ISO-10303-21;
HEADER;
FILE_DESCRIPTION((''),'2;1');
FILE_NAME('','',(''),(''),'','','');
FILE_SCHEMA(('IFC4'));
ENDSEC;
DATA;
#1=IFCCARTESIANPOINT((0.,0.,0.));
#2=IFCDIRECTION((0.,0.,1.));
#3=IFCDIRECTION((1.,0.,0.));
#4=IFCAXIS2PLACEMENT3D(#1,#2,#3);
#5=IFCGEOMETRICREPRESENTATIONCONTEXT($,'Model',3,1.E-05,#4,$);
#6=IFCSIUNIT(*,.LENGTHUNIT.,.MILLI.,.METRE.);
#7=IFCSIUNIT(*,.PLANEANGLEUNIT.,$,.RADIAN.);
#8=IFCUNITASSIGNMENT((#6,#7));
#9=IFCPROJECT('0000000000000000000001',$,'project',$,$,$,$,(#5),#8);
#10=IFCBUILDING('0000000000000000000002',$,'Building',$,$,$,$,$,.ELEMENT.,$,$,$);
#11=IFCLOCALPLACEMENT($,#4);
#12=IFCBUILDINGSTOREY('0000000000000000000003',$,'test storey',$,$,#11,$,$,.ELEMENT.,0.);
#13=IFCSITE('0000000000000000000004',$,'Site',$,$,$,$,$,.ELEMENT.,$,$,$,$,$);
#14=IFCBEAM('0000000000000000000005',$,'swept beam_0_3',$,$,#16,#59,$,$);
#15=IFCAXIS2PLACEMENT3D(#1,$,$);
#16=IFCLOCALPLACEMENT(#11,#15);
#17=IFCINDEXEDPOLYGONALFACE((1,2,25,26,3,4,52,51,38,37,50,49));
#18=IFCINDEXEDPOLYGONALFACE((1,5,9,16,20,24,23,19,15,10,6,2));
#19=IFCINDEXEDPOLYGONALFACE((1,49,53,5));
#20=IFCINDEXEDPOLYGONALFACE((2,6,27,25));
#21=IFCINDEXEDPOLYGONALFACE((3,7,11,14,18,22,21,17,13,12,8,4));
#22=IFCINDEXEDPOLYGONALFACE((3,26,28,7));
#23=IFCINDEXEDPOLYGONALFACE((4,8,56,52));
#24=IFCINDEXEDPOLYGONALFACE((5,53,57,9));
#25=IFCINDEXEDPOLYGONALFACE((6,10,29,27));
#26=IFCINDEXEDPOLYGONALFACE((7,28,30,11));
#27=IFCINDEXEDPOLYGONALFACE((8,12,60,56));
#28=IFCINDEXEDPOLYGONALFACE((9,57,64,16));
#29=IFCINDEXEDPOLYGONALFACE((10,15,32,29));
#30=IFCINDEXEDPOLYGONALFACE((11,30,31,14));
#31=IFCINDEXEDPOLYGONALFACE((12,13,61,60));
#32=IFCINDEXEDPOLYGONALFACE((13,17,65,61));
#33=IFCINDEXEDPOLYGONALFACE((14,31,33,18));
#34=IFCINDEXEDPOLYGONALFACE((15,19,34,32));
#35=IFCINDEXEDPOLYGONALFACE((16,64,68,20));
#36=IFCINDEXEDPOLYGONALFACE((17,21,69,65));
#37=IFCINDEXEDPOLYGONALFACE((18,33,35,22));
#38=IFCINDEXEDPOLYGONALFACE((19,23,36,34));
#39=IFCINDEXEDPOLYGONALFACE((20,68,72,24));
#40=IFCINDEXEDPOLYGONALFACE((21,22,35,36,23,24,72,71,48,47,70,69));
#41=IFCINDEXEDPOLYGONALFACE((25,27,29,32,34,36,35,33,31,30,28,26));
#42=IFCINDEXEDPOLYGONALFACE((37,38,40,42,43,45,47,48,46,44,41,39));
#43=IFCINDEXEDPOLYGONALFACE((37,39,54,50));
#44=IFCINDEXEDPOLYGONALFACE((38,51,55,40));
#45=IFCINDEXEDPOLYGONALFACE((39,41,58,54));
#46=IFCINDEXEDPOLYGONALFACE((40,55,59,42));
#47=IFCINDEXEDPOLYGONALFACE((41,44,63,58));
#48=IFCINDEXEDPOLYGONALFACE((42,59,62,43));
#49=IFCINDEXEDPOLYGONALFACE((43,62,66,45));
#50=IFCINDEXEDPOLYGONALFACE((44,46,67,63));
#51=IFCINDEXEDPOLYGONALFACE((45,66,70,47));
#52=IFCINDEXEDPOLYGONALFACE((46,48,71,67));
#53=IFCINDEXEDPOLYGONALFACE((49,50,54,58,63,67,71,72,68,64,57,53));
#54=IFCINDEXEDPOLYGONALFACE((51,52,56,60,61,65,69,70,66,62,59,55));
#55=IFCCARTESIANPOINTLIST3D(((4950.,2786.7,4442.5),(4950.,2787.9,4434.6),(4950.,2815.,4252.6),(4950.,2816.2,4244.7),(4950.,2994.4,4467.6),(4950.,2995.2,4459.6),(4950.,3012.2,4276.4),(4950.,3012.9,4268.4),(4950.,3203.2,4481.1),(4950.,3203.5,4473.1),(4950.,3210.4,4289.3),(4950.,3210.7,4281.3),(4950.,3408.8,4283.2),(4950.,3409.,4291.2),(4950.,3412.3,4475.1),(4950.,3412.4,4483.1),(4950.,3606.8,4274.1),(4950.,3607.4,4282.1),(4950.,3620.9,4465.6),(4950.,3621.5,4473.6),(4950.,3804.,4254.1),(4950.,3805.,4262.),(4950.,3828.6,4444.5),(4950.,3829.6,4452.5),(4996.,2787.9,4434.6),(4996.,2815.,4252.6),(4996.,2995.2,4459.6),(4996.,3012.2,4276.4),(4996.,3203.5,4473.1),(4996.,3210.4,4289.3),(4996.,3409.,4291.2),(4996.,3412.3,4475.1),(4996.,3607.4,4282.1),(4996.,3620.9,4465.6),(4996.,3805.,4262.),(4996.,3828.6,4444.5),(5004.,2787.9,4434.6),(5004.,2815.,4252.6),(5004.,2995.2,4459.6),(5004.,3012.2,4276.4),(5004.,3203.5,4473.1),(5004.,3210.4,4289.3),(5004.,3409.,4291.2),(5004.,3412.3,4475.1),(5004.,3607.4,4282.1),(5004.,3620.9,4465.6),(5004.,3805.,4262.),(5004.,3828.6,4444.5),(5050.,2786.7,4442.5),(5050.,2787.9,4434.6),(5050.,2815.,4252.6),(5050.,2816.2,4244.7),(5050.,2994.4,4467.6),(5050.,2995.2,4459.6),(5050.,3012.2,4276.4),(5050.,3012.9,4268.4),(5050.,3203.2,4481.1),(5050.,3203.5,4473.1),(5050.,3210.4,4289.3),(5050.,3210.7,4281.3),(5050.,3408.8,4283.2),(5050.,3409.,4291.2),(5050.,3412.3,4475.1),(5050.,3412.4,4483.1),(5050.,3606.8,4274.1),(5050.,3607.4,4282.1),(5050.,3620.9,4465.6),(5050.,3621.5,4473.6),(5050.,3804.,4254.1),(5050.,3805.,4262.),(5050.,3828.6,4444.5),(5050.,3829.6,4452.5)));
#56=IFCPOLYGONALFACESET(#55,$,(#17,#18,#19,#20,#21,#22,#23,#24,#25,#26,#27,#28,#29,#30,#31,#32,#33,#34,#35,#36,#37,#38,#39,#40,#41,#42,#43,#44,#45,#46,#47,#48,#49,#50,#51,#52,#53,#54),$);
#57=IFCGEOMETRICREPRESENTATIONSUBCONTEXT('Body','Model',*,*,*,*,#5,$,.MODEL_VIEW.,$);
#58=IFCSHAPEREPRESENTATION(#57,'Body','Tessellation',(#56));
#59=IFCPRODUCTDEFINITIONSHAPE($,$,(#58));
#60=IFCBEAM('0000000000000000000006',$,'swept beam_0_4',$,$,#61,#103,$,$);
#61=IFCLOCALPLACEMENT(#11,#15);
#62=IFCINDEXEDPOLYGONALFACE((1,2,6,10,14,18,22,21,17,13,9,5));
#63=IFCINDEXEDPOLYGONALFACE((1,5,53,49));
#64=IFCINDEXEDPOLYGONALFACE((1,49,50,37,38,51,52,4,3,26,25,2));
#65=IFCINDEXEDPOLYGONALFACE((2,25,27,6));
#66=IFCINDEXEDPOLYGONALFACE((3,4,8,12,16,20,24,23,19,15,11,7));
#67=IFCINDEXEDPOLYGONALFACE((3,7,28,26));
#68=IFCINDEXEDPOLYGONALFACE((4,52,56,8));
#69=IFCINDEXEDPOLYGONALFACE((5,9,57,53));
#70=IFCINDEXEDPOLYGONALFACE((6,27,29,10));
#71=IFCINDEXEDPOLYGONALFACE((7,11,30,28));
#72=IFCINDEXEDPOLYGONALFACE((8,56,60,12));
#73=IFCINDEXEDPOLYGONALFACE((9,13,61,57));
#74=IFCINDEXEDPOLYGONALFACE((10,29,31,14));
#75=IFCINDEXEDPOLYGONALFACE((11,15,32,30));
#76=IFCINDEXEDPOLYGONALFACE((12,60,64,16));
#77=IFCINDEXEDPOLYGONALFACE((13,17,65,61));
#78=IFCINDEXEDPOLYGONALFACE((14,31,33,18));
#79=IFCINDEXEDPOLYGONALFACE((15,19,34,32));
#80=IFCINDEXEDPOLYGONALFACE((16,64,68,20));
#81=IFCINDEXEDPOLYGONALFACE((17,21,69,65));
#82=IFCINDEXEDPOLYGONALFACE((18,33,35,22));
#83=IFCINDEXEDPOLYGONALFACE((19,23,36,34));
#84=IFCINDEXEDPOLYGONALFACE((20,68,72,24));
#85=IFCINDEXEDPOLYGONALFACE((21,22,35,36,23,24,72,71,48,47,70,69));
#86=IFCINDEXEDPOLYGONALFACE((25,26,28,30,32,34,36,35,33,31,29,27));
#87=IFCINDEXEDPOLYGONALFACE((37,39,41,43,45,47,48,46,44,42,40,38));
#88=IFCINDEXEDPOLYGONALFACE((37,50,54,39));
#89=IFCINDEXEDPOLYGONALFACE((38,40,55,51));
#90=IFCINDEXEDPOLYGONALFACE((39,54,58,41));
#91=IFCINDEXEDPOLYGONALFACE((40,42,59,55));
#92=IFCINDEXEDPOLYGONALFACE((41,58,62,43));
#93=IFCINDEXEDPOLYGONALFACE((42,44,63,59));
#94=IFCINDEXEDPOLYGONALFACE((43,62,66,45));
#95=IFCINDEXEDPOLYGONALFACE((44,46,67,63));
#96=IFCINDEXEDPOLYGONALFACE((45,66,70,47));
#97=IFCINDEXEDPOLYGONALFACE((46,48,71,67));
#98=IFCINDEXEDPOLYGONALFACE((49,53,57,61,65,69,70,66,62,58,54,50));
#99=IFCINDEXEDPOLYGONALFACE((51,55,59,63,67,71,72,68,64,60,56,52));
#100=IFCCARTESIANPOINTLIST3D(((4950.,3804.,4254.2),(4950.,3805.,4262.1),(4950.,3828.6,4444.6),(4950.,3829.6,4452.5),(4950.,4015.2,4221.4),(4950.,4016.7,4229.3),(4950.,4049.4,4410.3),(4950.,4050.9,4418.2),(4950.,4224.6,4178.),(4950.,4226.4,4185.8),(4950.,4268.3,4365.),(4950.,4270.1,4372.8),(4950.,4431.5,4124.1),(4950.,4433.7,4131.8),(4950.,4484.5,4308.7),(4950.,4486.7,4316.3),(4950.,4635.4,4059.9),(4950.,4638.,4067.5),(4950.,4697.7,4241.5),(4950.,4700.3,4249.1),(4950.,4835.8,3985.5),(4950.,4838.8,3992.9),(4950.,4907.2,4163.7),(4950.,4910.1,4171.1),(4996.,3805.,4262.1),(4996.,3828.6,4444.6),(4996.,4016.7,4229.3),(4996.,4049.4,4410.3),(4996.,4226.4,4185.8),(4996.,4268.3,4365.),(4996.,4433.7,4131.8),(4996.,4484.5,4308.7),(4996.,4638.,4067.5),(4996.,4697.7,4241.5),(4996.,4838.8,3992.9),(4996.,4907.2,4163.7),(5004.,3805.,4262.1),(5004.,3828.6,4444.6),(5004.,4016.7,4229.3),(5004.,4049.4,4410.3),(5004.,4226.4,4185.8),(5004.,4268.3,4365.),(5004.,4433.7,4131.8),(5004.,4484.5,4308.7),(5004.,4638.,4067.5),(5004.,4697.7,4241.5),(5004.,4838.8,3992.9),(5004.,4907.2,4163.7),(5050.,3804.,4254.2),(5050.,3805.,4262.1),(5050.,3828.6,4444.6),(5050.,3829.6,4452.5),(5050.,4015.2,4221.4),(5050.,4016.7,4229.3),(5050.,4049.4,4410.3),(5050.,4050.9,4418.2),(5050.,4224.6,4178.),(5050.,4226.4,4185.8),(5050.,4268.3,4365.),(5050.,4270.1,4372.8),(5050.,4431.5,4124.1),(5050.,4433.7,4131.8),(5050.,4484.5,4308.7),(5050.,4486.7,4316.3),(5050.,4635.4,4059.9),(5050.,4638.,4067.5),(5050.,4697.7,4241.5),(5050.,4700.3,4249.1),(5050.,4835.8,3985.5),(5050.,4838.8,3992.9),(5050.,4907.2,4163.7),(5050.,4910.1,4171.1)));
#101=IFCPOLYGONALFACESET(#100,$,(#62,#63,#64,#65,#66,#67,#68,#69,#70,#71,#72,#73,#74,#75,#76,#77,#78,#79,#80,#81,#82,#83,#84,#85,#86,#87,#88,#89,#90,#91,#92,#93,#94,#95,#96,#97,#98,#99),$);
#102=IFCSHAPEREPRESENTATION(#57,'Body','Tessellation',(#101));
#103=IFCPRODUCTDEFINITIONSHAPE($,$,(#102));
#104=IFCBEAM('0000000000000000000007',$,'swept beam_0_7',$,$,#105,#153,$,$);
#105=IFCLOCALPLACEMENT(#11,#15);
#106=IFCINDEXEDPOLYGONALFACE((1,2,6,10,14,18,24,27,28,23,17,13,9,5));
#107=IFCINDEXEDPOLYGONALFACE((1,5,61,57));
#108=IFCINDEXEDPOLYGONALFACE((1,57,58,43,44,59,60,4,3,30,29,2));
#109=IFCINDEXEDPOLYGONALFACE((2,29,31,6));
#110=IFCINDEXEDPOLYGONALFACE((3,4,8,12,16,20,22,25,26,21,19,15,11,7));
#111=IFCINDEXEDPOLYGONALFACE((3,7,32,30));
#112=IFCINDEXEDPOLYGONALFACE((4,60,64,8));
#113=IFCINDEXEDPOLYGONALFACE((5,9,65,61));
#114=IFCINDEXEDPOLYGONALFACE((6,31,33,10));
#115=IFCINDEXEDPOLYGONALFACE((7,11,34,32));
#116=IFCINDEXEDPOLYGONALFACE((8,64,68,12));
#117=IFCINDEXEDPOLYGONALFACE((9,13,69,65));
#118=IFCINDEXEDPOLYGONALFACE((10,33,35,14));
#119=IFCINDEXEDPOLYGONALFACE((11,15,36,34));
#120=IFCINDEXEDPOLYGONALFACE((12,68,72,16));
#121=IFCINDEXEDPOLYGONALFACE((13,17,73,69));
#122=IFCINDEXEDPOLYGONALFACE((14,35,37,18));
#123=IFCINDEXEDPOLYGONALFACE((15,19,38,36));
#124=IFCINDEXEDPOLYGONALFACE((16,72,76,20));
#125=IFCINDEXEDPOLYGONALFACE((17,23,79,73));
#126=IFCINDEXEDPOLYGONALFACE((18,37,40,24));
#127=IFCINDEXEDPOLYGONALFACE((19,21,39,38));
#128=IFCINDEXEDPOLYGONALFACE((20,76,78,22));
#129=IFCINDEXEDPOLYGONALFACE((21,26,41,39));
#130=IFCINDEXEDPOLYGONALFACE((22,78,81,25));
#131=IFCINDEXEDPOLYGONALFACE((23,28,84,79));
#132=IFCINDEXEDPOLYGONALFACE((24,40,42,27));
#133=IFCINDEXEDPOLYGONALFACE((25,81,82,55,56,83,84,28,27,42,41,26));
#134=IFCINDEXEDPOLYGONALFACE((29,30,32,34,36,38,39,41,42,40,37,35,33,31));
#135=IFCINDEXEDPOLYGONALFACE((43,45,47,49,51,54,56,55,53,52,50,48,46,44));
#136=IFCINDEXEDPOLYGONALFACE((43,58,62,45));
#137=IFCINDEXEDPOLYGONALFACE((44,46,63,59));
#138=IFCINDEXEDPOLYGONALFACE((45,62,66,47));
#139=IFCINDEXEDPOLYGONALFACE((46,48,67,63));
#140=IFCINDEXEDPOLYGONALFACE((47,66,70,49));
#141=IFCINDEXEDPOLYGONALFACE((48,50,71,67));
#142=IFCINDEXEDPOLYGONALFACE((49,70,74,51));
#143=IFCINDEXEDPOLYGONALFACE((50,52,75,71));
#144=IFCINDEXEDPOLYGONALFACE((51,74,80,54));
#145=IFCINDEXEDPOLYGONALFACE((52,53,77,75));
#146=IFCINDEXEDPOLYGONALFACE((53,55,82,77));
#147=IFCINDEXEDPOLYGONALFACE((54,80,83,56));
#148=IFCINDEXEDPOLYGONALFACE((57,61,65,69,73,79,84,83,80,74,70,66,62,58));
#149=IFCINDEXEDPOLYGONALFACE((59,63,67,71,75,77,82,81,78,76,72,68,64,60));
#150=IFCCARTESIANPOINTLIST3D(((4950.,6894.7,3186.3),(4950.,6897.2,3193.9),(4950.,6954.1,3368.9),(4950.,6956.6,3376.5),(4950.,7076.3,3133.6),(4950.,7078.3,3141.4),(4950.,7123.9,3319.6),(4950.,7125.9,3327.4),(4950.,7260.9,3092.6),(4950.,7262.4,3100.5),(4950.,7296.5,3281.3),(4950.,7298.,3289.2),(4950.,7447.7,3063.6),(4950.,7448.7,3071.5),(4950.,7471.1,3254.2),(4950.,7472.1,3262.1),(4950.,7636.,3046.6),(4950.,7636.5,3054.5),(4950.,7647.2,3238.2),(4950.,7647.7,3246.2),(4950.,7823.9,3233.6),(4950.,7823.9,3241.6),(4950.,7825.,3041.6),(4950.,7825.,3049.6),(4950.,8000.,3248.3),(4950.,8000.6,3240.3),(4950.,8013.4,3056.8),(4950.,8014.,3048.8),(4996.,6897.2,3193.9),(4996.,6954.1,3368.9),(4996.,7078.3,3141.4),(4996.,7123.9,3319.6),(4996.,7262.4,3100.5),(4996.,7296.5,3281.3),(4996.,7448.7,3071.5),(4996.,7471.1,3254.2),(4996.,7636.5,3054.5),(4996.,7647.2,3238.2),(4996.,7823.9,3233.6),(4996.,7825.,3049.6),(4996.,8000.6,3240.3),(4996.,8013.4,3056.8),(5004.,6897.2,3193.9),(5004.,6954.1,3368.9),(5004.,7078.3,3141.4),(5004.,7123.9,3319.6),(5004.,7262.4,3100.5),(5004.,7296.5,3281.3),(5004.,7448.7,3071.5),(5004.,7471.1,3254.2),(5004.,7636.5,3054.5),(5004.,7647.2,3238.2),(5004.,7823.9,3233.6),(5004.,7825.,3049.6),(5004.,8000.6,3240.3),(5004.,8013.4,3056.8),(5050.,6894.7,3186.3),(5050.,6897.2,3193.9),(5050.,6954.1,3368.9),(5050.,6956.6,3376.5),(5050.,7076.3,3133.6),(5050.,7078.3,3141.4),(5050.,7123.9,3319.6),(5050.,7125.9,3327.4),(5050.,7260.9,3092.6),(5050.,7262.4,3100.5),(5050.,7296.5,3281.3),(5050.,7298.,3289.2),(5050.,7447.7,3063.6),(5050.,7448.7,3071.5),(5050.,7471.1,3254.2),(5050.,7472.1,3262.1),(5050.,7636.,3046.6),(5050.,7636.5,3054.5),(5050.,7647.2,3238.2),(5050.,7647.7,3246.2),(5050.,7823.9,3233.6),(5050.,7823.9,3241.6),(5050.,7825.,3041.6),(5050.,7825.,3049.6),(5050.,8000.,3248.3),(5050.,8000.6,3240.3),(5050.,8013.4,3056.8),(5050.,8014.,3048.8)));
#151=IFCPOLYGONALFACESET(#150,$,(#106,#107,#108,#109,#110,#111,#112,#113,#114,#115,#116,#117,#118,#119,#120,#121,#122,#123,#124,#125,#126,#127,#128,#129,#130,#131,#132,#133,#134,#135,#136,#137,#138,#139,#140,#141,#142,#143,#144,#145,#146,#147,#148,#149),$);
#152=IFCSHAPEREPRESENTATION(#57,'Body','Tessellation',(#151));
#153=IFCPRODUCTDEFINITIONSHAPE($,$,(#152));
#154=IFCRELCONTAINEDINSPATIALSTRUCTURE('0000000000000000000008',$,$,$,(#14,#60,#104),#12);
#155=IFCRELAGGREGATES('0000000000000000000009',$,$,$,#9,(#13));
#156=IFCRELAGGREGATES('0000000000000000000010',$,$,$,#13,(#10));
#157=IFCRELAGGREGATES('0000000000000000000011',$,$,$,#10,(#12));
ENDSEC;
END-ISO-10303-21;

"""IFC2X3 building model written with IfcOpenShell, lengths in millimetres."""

from ifc_helpers import new_model, entity, si_unit, origin_with_axes, place, context, subcontext, project, spatial, element, save


model = new_model("IFC2X3")

# Units and contexts
model_context = context("Model", 3, precision=1e-05, world=origin_with_axes())
body_context = subcontext(model_context, "Body", "Model", "MODEL_VIEW")
ifc_project = project(units=[si_unit("LENGTHUNIT", "METRE", prefix="MILLI"), si_unit("PLANEANGLEUNIT", "RADIAN")], contexts=[model_context])

# Site, building, storey
site = spatial("IfcSite", under=ifc_project, Name="Site", CompositionType="ELEMENT")
building = spatial("IfcBuilding", under=site, Name="Building", CompositionType="ELEMENT")
storey_placement = place(None, origin_with_axes())
storey = spatial("IfcBuildingStorey", under=building, at=storey_placement, Name="test storey", CompositionType="ELEMENT", Elevation=0.0)

# Beams
beam_1_placement = place(storey_placement, origin_with_axes())
element("IfcBeam", 1, at=beam_1_placement, inside=storey, Name="swept beam_0_3", context=body_context, shape_type="SweptSolid", body=[
    entity("IfcRevolvedAreaSolid", entity("IfcArbitraryClosedProfileDef", "AREA", None, entity("IfcPolyline", [entity("IfcCartesianPoint", [-192.0, -50.0]), entity("IfcCartesianPoint", [-192.0, -4.0]), entity("IfcCartesianPoint", [-8.0, -4.0]), entity("IfcCartesianPoint", [-8.0, -50.0]), entity("IfcCartesianPoint", [0.0, -50.0]), entity("IfcCartesianPoint", [0.0, 50.0]), entity("IfcCartesianPoint", [-8.0, 50.0]), entity("IfcCartesianPoint", [-8.0, 4.0]), entity("IfcCartesianPoint", [-192.0, 4.0]), entity("IfcCartesianPoint", [-192.0, 50.0]), entity("IfcCartesianPoint", [-200.0, 50.0]), entity("IfcCartesianPoint", [-200.0, -50.0]), entity("IfcCartesianPoint", [-192.0, -50.0])])), entity("IfcAxis2Placement3D", entity("IfcCartesianPoint", [5000.0, 2786.7, 4442.5]), entity("IfcDirection", [0.0, -0.9891, -0.1473]), entity("IfcDirection", [0.0, -0.1473, 0.9891])), entity("IfcAxis1Placement", entity("IfcCartesianPoint", [-3783.4, 0.0, 0.0]), entity("IfcDirection", [0.0, 1.0, 0.0])), 0.276549),
])
beam_2_placement = place(storey_placement, origin_with_axes())
element("IfcBeam", 2, at=beam_2_placement, inside=storey, Name="swept beam_0_4", context=body_context, shape_type="SweptSolid", body=[
    entity("IfcRevolvedAreaSolid", entity("IfcArbitraryClosedProfileDef", "AREA", None, entity("IfcPolyline", [entity("IfcCartesianPoint", [-192.0, -50.0]), entity("IfcCartesianPoint", [-192.0, -4.0]), entity("IfcCartesianPoint", [-8.0, -4.0]), entity("IfcCartesianPoint", [-8.0, -50.0]), entity("IfcCartesianPoint", [0.0, -50.0]), entity("IfcCartesianPoint", [0.0, 50.0]), entity("IfcCartesianPoint", [-8.0, 50.0]), entity("IfcCartesianPoint", [-8.0, 4.0]), entity("IfcCartesianPoint", [-192.0, 4.0]), entity("IfcCartesianPoint", [-192.0, 50.0]), entity("IfcCartesianPoint", [-200.0, 50.0]), entity("IfcCartesianPoint", [-200.0, -50.0]), entity("IfcCartesianPoint", [-192.0, -50.0])])), entity("IfcAxis2Placement3D", entity("IfcCartesianPoint", [5000.0, 3829.6, 4452.5]), entity("IfcDirection", [0.0, -0.9917, 0.1283]), entity("IfcDirection", [0.0, 0.1283, 0.9917])), entity("IfcAxis1Placement", entity("IfcCartesianPoint", [-4439.5, 0.0, 0.0]), entity("IfcDirection", [0.0, 1.0, 0.0])), 0.252168),
])
beam_3_placement = place(storey_placement, origin_with_axes())
element("IfcBeam", 3, at=beam_3_placement, inside=storey, Name="swept beam_0_7", context=body_context, shape_type="SweptSolid", body=[
    entity("IfcRevolvedAreaSolid", entity("IfcArbitraryClosedProfileDef", "AREA", None, entity("IfcPolyline", [entity("IfcCartesianPoint", [192.0, 50.0]), entity("IfcCartesianPoint", [192.0, 4.0]), entity("IfcCartesianPoint", [8.0, 4.0]), entity("IfcCartesianPoint", [8.0, 50.0]), entity("IfcCartesianPoint", [0.0, 50.0]), entity("IfcCartesianPoint", [0.0, -50.0]), entity("IfcCartesianPoint", [8.0, -50.0]), entity("IfcCartesianPoint", [8.0, -4.0]), entity("IfcCartesianPoint", [192.0, -4.0]), entity("IfcCartesianPoint", [192.0, -50.0]), entity("IfcCartesianPoint", [200.0, -50.0]), entity("IfcCartesianPoint", [200.0, 50.0]), entity("IfcCartesianPoint", [192.0, 50.0])])), entity("IfcAxis2Placement3D", entity("IfcCartesianPoint", [5000.0, 6956.6, 3376.5]), entity("IfcDirection", [0.0, -0.951, 0.3093]), entity("IfcDirection", [0.0, -0.3093, -0.951])), entity("IfcAxis1Placement", entity("IfcCartesianPoint", [-2751.9, 0.0, 0.0]), entity("IfcDirection", [0.0, 1.0, 0.0])), 0.384371),
])

save(model, "model.ifc")
